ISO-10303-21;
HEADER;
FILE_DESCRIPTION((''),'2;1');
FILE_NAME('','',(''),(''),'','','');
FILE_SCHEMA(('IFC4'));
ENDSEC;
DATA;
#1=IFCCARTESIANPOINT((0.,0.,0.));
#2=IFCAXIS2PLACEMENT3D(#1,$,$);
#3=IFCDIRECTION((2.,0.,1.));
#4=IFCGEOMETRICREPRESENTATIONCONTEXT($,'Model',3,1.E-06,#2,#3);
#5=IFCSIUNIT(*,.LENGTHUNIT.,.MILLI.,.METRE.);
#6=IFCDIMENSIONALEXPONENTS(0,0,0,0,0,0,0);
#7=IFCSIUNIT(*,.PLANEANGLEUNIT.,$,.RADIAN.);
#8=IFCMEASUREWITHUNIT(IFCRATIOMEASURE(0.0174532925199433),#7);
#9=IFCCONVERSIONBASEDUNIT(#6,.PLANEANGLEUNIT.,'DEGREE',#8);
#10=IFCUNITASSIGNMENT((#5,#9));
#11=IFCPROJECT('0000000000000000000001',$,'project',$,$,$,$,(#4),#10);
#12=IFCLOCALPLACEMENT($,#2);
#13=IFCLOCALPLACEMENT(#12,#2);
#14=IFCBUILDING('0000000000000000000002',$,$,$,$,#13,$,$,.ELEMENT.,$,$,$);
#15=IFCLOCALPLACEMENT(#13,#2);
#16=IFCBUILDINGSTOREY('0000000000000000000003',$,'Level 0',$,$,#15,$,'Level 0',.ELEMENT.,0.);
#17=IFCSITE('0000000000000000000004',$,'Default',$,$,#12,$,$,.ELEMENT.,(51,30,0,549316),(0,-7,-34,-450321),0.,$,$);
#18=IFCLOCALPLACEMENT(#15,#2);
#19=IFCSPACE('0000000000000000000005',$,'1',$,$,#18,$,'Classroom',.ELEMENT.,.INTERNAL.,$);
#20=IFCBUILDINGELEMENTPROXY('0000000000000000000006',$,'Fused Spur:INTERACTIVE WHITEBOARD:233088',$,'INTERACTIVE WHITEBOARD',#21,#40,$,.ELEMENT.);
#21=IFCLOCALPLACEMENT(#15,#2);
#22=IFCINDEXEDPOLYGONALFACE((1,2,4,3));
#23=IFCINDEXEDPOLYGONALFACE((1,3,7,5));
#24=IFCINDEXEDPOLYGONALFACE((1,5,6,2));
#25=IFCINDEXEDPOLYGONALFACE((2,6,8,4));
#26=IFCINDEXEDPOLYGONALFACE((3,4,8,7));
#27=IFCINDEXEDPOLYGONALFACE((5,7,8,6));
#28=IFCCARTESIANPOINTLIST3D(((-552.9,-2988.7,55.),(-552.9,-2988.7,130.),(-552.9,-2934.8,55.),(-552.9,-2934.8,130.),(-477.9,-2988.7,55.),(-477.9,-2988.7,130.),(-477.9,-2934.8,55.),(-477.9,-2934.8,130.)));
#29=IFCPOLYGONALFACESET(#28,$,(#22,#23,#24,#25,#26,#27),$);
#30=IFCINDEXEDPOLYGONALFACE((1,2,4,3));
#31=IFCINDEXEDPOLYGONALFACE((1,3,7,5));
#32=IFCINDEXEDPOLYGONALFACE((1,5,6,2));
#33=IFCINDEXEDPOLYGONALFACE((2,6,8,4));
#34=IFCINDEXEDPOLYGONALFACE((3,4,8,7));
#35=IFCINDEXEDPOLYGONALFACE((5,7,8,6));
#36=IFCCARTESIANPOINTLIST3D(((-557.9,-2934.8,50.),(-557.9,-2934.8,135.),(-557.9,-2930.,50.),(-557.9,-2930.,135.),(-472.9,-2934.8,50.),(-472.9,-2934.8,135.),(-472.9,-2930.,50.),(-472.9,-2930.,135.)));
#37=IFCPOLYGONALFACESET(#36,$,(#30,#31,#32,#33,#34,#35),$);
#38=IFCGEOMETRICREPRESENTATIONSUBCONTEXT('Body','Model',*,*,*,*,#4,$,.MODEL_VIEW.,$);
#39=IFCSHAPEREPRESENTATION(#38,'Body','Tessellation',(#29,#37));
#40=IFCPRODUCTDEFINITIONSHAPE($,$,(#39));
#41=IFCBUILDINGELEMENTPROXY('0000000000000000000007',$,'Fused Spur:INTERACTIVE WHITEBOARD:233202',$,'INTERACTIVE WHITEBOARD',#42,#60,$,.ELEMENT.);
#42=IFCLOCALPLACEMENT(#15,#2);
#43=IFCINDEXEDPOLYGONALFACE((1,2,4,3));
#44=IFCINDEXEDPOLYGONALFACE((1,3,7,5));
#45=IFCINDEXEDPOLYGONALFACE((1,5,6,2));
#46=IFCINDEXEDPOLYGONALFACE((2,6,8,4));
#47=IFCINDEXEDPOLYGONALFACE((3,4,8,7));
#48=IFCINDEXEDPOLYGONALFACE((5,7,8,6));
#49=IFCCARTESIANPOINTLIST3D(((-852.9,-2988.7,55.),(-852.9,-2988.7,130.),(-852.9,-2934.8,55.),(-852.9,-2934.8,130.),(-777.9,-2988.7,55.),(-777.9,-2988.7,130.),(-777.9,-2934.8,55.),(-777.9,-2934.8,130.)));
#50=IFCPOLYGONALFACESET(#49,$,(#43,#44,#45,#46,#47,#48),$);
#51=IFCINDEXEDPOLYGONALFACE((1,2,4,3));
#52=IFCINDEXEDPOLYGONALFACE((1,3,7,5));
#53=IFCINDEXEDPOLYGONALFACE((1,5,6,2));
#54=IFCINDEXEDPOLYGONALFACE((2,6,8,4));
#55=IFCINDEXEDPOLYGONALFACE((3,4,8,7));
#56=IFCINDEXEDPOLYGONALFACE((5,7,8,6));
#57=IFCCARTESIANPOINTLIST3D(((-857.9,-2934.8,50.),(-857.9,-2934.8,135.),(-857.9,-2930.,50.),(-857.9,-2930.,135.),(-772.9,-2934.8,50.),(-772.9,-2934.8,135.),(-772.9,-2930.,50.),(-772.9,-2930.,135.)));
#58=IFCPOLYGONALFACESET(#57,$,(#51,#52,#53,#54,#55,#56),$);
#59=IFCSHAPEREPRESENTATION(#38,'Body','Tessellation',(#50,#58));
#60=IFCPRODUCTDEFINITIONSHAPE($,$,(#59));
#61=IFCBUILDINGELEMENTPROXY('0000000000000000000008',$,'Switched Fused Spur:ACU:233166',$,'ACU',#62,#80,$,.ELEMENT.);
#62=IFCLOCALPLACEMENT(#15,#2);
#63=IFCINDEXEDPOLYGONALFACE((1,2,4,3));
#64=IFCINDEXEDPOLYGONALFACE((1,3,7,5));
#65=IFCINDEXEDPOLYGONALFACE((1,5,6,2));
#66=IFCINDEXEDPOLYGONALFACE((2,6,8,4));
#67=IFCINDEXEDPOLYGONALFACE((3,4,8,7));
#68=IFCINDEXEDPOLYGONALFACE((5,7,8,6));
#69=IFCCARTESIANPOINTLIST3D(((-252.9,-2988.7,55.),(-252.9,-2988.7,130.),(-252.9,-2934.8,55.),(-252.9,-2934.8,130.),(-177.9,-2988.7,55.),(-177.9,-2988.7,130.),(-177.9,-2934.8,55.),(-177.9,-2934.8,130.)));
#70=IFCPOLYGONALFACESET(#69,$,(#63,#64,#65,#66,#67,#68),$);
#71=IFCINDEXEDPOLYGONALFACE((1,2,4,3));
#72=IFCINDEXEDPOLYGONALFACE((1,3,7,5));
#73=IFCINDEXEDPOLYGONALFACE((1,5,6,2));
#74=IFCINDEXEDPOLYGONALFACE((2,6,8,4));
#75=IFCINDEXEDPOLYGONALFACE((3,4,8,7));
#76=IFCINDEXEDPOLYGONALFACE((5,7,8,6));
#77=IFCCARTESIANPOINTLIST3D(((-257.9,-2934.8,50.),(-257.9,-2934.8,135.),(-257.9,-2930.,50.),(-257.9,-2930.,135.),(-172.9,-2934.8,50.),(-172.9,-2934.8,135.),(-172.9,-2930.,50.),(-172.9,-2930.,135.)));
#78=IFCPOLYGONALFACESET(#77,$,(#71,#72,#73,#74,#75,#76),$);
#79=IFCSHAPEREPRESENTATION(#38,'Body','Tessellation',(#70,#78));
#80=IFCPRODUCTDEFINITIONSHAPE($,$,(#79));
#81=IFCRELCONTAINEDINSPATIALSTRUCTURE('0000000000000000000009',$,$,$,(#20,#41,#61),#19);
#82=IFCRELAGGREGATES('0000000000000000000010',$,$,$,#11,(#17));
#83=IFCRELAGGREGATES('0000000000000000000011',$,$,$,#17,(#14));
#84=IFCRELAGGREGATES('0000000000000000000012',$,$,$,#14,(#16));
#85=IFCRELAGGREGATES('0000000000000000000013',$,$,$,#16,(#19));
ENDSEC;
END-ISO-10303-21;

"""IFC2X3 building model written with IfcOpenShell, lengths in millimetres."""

from ifc_helpers import new_model, entity, si_unit, converted_unit, direction, frame, frame_2d, origin, place, context, subcontext, project, spatial, rectangle, extrude, source, transform, mapped, element, save


model = new_model("IFC2X3")

# Units and contexts
model_context = context("Model", 3, precision=1e-06, world=origin(), true_north=direction((2.0, 0.0, 1.0)))
body_context = subcontext(model_context, "Body", "Model", "MODEL_VIEW")
ifc_project = project(units=[si_unit("LENGTHUNIT", "METRE", prefix="MILLI"), converted_unit("PLANEANGLEUNIT", "DEGREE", entity("IfcRatioMeasure", 0.0174532925199433), si_unit("PLANEANGLEUNIT", "RADIAN"), dimensions=[0, 0, 0, 0, 0, 0, 0])], contexts=[model_context])

# Site, building, storey
site_placement = place(None, origin())
site = spatial("IfcSite", under=ifc_project, at=site_placement, Name="Default", CompositionType="ELEMENT", RefLatitude=(51, 30, 0, 549316), RefLongitude=(0, -7, -34, -450321), RefElevation=0.0)
building_placement = place(site_placement, origin())
building = spatial("IfcBuilding", under=site, at=building_placement, CompositionType="ELEMENT")
storey_placement = place(building_placement, origin())
storey = spatial("IfcBuildingStorey", under=building, at=storey_placement, Name="Level 0", LongName="Level 0", CompositionType="ELEMENT", Elevation=0.0)

# Shared definitions
space_placement = place(storey_placement, origin())
space = spatial("IfcSpace", under=storey, at=space_placement, Name="1", LongName="Classroom", CompositionType="ELEMENT", InteriorOrExteriorSpace="INTERNAL")

# Building element proxies
shared_shape_1 = source(origin(), body_context, "Body", "SweptSolid", [
    extrude(rectangle(XDim=75.0, YDim=75.0, at=frame_2d((0.0, 0.0), x_axis=(1.0, 0.0))), frame((0.0, 0.0, -54.0), z_axis=(0.0, 0.0, 1.0), x_axis=(-1.0, 0.0, 0.0)), (0.0, 0.0, 1.0), 54.0),
    extrude(rectangle(XDim=85.0, YDim=85.0, at=frame_2d((0.0, 0.0), x_axis=(1.0, 0.0))), frame((0.0, 0.0, 0.0), z_axis=(0.0, 0.0, 1.0), x_axis=(-1.0, 0.0, 0.0)), (0.0, 0.0, 1.0), 4.8),
])
for number, where, z_axis, x_axis, name in (
    (1, (-515.4, -2934.8, 92.5), (0.0, 1.0, 0.0), (-1.0, 0.0, 0.0), "Fused Spur:INTERACTIVE WHITEBOARD:233088"),
    (2, (-815.4, -2934.8, 92.5), (0.0, 1.0, 0.0), (-1.0, 0.0, 0.0), "Fused Spur:INTERACTIVE WHITEBOARD:233202"),
):
    element("IfcBuildingElementProxy", number, at=place(space_placement, frame(where, z_axis=z_axis, x_axis=x_axis)), inside=space, Name=name, ObjectType="INTERACTIVE WHITEBOARD", CompositionType="ELEMENT", context=body_context, shape_type="MappedRepresentation", body=[
        mapped(shared_shape_1, transform((0.0, 0.0, 0.0), scale=1.0)),
    ])
shared_shape_2 = source(origin(), body_context, "Body", "SweptSolid", [
    extrude(rectangle(XDim=75.0, YDim=75.0, at=frame_2d((0.0, 0.0), x_axis=(1.0, 0.0))), frame((0.0, 0.0, -54.0), z_axis=(0.0, 0.0, 1.0), x_axis=(-1.0, 0.0, 0.0)), (0.0, 0.0, 1.0), 54.0),
    extrude(rectangle(XDim=85.0, YDim=85.0, at=frame_2d((0.0, 0.0), x_axis=(1.0, 0.0))), frame((0.0, 0.0, 0.0), z_axis=(0.0, 0.0, 1.0), x_axis=(-1.0, 0.0, 0.0)), (0.0, 0.0, 1.0), 4.8),
])
proxy_1_placement = place(space_placement, frame((-215.4, -2934.8, 92.5), z_axis=(0.0, 1.0, 0.0), x_axis=(-1.0, 0.0, 0.0)))
element("IfcBuildingElementProxy", 3, at=proxy_1_placement, inside=space, Name="Switched Fused Spur:ACU:233166", ObjectType="ACU", CompositionType="ELEMENT", context=body_context, shape_type="MappedRepresentation", body=[
    mapped(shared_shape_2, transform((0.0, 0.0, 0.0), scale=1.0)),
])

save(model, "model.ifc")
